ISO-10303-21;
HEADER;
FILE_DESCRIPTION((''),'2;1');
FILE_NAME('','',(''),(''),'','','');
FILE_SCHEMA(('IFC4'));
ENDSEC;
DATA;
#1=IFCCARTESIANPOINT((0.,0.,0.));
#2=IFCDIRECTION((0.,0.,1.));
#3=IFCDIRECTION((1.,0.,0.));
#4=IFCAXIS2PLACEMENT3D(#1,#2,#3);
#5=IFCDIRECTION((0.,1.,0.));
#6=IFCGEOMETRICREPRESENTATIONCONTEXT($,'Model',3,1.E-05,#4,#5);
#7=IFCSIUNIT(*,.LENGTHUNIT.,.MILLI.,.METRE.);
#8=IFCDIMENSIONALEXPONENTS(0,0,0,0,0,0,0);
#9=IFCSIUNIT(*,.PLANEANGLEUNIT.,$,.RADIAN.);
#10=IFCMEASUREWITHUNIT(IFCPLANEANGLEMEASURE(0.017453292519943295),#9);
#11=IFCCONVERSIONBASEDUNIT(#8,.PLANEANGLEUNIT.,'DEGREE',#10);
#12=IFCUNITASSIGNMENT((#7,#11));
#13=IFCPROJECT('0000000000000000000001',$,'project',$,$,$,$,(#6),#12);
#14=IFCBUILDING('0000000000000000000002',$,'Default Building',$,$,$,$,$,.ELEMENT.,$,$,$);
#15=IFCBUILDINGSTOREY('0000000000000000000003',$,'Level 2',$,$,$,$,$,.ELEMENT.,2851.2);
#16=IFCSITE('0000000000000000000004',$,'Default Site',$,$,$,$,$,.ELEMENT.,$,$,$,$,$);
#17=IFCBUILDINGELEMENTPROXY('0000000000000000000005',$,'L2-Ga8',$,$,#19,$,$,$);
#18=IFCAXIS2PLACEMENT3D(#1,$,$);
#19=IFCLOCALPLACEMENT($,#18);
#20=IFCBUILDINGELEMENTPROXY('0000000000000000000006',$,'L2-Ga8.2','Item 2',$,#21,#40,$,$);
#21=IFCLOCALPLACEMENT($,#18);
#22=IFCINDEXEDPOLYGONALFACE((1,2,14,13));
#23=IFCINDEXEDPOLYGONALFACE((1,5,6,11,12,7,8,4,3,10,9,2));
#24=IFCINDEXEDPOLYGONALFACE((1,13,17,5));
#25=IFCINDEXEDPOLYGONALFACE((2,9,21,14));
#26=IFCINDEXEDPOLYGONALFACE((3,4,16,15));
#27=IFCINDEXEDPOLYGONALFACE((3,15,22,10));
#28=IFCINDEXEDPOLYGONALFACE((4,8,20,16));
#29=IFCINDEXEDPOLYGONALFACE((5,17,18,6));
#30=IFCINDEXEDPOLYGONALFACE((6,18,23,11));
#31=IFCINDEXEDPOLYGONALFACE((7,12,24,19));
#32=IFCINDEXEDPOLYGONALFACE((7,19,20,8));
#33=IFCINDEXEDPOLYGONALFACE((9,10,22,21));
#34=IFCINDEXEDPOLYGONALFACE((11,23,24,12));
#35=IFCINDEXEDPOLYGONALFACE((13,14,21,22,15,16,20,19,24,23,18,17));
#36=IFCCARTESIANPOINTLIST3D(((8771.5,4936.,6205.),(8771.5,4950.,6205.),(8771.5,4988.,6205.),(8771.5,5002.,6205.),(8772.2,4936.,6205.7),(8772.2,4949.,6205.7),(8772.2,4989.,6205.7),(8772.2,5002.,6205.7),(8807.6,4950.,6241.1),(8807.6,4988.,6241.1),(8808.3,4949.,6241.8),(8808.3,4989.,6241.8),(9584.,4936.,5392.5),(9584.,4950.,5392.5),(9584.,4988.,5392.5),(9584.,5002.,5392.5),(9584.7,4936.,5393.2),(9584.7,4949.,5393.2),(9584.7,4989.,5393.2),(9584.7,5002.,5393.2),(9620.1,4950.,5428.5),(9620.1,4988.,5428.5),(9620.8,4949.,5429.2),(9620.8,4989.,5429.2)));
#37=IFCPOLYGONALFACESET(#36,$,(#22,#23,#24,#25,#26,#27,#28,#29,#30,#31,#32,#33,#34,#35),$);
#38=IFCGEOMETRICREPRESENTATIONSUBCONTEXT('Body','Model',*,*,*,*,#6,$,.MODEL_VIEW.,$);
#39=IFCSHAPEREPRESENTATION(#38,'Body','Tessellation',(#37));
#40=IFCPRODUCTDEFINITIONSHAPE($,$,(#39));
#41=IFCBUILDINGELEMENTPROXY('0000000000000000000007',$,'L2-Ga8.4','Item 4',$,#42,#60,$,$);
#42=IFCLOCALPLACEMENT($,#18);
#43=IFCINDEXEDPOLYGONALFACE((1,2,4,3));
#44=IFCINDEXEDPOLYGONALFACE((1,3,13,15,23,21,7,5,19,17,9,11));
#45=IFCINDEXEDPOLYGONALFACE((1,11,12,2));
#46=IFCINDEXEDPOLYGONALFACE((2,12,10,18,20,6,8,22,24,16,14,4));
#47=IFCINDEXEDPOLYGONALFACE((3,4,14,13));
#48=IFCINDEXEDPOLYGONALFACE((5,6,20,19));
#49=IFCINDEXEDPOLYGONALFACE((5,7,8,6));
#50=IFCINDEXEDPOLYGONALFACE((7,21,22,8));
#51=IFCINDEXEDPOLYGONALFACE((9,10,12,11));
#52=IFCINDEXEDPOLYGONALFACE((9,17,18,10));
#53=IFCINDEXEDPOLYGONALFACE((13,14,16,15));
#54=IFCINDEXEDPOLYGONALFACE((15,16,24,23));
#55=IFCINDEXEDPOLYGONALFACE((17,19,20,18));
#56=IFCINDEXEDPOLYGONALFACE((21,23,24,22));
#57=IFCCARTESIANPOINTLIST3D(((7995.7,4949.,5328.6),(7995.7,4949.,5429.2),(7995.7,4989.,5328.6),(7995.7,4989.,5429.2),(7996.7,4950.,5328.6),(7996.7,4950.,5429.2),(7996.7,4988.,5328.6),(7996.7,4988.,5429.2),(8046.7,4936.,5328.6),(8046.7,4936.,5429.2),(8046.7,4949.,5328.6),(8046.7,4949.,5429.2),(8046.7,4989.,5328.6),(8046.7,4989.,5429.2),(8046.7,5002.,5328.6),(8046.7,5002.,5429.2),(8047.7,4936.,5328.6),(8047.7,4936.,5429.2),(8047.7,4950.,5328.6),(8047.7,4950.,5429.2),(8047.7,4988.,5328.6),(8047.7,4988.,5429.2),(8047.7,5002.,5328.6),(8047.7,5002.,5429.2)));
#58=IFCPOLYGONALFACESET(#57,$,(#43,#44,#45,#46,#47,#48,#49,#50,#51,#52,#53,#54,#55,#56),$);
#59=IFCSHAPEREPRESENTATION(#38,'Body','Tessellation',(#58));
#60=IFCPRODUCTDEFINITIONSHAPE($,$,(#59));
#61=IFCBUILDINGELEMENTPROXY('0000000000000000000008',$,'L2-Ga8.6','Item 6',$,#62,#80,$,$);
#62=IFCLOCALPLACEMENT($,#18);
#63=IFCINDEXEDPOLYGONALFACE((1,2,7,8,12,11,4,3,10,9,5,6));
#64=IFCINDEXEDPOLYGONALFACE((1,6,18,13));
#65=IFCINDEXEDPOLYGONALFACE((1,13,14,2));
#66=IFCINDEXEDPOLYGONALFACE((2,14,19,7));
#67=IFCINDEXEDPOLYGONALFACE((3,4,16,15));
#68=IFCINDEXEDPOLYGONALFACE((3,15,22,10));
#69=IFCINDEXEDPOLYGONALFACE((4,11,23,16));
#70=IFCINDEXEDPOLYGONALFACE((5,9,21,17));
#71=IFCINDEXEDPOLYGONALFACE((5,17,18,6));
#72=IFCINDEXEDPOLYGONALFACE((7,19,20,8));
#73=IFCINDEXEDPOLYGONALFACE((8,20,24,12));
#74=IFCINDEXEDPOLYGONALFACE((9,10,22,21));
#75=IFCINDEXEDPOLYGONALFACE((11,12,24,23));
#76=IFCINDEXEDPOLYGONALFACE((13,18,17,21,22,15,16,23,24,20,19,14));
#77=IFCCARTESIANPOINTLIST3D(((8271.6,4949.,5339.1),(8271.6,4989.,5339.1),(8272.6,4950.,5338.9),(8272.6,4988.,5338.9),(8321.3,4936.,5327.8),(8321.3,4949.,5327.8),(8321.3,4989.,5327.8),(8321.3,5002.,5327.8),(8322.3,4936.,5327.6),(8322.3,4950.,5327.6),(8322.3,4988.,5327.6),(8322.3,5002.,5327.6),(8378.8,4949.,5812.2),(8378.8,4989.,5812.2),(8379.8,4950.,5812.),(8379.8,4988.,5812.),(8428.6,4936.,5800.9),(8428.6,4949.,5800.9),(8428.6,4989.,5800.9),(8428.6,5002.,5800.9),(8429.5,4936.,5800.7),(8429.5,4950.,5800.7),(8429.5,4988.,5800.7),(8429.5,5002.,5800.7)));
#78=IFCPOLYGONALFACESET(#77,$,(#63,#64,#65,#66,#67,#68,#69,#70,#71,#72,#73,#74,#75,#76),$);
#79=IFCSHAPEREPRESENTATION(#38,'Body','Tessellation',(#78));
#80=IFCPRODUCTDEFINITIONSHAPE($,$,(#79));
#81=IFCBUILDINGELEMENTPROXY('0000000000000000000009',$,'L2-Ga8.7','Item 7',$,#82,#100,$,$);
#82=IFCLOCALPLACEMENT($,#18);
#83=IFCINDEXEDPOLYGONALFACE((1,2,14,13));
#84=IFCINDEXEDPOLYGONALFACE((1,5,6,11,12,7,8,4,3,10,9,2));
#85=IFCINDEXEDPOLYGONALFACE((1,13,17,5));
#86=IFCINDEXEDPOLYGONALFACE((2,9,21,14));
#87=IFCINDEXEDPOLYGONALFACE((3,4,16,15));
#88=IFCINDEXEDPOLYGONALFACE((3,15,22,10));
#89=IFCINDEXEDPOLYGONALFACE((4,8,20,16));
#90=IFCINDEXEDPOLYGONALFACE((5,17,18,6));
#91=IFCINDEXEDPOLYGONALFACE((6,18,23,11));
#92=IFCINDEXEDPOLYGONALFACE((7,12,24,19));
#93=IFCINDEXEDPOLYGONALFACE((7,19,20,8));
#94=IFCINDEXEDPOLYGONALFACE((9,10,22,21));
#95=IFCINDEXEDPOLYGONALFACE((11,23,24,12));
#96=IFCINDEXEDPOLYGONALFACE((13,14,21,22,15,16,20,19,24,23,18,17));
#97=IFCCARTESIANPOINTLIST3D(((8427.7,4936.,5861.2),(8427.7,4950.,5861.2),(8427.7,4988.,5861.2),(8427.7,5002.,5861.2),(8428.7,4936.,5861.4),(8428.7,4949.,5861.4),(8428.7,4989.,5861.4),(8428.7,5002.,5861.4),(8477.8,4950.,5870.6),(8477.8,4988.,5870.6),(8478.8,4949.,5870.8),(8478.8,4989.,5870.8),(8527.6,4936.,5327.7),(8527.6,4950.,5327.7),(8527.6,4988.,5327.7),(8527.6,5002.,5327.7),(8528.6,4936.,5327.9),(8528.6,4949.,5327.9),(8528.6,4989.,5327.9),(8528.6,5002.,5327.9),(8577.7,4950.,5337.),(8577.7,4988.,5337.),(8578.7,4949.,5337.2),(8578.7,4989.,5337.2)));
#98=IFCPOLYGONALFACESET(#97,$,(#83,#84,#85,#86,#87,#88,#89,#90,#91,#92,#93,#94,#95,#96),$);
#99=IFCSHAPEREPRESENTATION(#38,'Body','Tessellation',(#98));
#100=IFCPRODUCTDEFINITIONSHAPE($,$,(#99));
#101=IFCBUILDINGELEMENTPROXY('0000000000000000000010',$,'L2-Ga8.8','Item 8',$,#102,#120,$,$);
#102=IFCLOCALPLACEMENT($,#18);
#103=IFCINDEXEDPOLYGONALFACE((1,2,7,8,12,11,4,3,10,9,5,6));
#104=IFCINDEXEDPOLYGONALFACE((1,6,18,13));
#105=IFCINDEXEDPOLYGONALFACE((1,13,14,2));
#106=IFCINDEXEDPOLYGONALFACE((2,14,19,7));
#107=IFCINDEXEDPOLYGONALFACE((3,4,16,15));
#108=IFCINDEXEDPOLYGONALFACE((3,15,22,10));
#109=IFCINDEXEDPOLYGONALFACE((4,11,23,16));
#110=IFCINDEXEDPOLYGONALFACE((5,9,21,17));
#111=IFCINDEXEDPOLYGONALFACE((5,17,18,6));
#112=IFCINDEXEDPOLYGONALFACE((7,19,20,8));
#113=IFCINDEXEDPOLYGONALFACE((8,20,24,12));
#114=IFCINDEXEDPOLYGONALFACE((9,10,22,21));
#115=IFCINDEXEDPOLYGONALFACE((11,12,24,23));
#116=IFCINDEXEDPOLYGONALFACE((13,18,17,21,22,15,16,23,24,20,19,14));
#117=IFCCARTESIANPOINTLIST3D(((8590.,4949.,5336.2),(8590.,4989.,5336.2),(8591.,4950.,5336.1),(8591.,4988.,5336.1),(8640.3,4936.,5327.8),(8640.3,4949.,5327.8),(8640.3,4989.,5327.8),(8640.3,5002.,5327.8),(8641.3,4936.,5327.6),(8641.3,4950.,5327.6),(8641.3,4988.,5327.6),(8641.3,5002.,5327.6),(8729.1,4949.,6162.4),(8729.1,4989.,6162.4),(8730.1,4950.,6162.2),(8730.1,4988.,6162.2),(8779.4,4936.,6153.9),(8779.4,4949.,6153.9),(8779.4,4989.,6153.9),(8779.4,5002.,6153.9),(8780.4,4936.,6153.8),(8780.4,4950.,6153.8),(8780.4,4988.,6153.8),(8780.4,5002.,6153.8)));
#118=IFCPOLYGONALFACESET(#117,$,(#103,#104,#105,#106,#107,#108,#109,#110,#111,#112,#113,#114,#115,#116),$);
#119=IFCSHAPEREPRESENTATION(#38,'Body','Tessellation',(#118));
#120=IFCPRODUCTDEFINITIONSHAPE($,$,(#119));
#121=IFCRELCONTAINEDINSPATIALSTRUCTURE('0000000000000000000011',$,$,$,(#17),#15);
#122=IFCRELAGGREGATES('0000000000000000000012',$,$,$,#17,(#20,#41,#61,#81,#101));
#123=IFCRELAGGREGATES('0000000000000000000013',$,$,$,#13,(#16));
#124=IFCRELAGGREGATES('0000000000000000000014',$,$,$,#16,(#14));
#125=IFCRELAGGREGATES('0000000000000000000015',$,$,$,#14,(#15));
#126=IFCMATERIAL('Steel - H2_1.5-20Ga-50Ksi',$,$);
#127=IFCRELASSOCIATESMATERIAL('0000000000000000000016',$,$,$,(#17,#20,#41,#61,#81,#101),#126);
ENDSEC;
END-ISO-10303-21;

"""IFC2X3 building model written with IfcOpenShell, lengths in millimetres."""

from ifc_helpers import new_model, entity, si_unit, converted_unit, direction, frame, origin, origin_with_axes, place, context, subcontext, project, spatial, polyline, outline, extrude, material, element, aggregate, save


model = new_model("IFC2X3")

# Units and contexts
model_context = context("Model", 3, precision=1e-05, world=origin_with_axes(), true_north=direction((0.0, 1.0, 0.0)))
body_context = subcontext(model_context, "Body", "Model", "MODEL_VIEW")
ifc_project = project(units=[si_unit("LENGTHUNIT", "METRE", prefix="MILLI"), converted_unit("PLANEANGLEUNIT", "DEGREE", entity("IfcPlaneAngleMeasure", 0.017453292519943295), si_unit("PLANEANGLEUNIT", "RADIAN"), dimensions=[0, 0, 0, 0, 0, 0, 0])], contexts=[model_context])

# Site, building, storey
site = spatial("IfcSite", under=ifc_project, Name="Default Site", CompositionType="ELEMENT")
building = spatial("IfcBuilding", under=site, Name="Default Building", CompositionType="ELEMENT")
storey = spatial("IfcBuildingStorey", under=building, Name="Level 2", CompositionType="ELEMENT", Elevation=2851.2)

# Building element proxies
ifc_material_1 = material(Name="Steel - H2_1.5-20Ga-50Ksi")
proxy_1 = element("IfcBuildingElementProxy", 1, inside=storey, material=ifc_material_1, Name="L2-Ga8")
proxy_2_placement = place(None, frame((8771.5, 4936.0, 6205.0), z_axis=(0.707, 0.0, -0.707), x_axis=(0.0, 40.0, 0.0)))
proxy_2 = element("IfcBuildingElementProxy", 2, at=proxy_2_placement, material=ifc_material_1, Name="L2-Ga8.2", Description="Item 2", context=body_context, shape_type="SweptSolid", body=[
    extrude(outline(polyline([(0.0, 0.0), (14.0, 0.0), (14.0, 51.0), (52.0, 51.0), (52.0, 0.0), (66.0, 0.0), (66.0, 1.0), (53.0, 1.0), (53.0, 52.0), (13.0, 52.0), (13.0, 1.0), (0.0, 1.0), (0.0, 0.0)])), origin(), (0.0, 0.0, 1.0), 1149.1),
])
proxy_3_placement = place(None, frame((8047.7, 4936.0, 5328.6), z_axis=(0.0, 0.0, 1.0), x_axis=(0.0, 40.0, 0.0)))
proxy_3 = element("IfcBuildingElementProxy", 3, at=proxy_3_placement, material=ifc_material_1, Name="L2-Ga8.4", Description="Item 4", context=body_context, shape_type="SweptSolid", body=[
    extrude(outline(polyline([(0.0, 0.0), (14.0, 0.0), (14.0, 51.0), (52.0, 51.0), (52.0, 0.0), (66.0, 0.0), (66.0, 1.0), (53.0, 1.0), (53.0, 52.0), (13.0, 52.0), (13.0, 1.0), (0.0, 1.0), (0.0, 0.0)])), origin(), (0.0, 0.0, 1.0), 100.6),
])
proxy_4_placement = place(None, frame((8322.3, 4936.0, 5327.6), z_axis=(0.221, 0.0, 0.975), x_axis=(0.0, 40.0, 0.0)))
proxy_4 = element("IfcBuildingElementProxy", 4, at=proxy_4_placement, material=ifc_material_1, Name="L2-Ga8.6", Description="Item 6", context=body_context, shape_type="SweptSolid", body=[
    extrude(outline(polyline([(0.0, 0.0), (14.0, 0.0), (14.0, 51.0), (52.0, 51.0), (52.0, 0.0), (66.0, 0.0), (66.0, 1.0), (53.0, 1.0), (53.0, 52.0), (13.0, 52.0), (13.0, 1.0), (0.0, 1.0), (0.0, 0.0)])), origin(), (0.0, 0.0, 1.0), 485.1),
])
proxy_5_placement = place(None, frame((8427.7, 4936.0, 5861.2), z_axis=(0.184, 0.0, -0.983), x_axis=(0.0, 40.0, 0.0)))
proxy_5 = element("IfcBuildingElementProxy", 5, at=proxy_5_placement, material=ifc_material_1, Name="L2-Ga8.7", Description="Item 7", context=body_context, shape_type="SweptSolid", body=[
    extrude(outline(polyline([(0.0, 0.0), (14.0, 0.0), (14.0, 51.0), (52.0, 51.0), (52.0, 0.0), (66.0, 0.0), (66.0, 1.0), (53.0, 1.0), (53.0, 52.0), (13.0, 52.0), (13.0, 1.0), (0.0, 1.0), (0.0, 0.0)])), origin(), (0.0, 0.0, 1.0), 542.8),
])
proxy_6_placement = place(None, frame((8641.3, 4936.0, 5327.6), z_axis=(0.166, 0.0, 0.986), x_axis=(0.0, 40.0, 0.0)))
proxy_6 = element("IfcBuildingElementProxy", 6, at=proxy_6_placement, material=ifc_material_1, Name="L2-Ga8.8", Description="Item 8", context=body_context, shape_type="SweptSolid", body=[
    extrude(outline(polyline([(0.0, 0.0), (14.0, 0.0), (14.0, 51.0), (52.0, 51.0), (52.0, 0.0), (66.0, 0.0), (66.0, 1.0), (53.0, 1.0), (53.0, 52.0), (13.0, 52.0), (13.0, 1.0), (0.0, 1.0), (0.0, 0.0)])), origin(), (0.0, 0.0, 1.0), 837.8),
])
aggregate(proxy_1, [proxy_2, proxy_3, proxy_4, proxy_5, proxy_6])

save(model, "model.ifc")
